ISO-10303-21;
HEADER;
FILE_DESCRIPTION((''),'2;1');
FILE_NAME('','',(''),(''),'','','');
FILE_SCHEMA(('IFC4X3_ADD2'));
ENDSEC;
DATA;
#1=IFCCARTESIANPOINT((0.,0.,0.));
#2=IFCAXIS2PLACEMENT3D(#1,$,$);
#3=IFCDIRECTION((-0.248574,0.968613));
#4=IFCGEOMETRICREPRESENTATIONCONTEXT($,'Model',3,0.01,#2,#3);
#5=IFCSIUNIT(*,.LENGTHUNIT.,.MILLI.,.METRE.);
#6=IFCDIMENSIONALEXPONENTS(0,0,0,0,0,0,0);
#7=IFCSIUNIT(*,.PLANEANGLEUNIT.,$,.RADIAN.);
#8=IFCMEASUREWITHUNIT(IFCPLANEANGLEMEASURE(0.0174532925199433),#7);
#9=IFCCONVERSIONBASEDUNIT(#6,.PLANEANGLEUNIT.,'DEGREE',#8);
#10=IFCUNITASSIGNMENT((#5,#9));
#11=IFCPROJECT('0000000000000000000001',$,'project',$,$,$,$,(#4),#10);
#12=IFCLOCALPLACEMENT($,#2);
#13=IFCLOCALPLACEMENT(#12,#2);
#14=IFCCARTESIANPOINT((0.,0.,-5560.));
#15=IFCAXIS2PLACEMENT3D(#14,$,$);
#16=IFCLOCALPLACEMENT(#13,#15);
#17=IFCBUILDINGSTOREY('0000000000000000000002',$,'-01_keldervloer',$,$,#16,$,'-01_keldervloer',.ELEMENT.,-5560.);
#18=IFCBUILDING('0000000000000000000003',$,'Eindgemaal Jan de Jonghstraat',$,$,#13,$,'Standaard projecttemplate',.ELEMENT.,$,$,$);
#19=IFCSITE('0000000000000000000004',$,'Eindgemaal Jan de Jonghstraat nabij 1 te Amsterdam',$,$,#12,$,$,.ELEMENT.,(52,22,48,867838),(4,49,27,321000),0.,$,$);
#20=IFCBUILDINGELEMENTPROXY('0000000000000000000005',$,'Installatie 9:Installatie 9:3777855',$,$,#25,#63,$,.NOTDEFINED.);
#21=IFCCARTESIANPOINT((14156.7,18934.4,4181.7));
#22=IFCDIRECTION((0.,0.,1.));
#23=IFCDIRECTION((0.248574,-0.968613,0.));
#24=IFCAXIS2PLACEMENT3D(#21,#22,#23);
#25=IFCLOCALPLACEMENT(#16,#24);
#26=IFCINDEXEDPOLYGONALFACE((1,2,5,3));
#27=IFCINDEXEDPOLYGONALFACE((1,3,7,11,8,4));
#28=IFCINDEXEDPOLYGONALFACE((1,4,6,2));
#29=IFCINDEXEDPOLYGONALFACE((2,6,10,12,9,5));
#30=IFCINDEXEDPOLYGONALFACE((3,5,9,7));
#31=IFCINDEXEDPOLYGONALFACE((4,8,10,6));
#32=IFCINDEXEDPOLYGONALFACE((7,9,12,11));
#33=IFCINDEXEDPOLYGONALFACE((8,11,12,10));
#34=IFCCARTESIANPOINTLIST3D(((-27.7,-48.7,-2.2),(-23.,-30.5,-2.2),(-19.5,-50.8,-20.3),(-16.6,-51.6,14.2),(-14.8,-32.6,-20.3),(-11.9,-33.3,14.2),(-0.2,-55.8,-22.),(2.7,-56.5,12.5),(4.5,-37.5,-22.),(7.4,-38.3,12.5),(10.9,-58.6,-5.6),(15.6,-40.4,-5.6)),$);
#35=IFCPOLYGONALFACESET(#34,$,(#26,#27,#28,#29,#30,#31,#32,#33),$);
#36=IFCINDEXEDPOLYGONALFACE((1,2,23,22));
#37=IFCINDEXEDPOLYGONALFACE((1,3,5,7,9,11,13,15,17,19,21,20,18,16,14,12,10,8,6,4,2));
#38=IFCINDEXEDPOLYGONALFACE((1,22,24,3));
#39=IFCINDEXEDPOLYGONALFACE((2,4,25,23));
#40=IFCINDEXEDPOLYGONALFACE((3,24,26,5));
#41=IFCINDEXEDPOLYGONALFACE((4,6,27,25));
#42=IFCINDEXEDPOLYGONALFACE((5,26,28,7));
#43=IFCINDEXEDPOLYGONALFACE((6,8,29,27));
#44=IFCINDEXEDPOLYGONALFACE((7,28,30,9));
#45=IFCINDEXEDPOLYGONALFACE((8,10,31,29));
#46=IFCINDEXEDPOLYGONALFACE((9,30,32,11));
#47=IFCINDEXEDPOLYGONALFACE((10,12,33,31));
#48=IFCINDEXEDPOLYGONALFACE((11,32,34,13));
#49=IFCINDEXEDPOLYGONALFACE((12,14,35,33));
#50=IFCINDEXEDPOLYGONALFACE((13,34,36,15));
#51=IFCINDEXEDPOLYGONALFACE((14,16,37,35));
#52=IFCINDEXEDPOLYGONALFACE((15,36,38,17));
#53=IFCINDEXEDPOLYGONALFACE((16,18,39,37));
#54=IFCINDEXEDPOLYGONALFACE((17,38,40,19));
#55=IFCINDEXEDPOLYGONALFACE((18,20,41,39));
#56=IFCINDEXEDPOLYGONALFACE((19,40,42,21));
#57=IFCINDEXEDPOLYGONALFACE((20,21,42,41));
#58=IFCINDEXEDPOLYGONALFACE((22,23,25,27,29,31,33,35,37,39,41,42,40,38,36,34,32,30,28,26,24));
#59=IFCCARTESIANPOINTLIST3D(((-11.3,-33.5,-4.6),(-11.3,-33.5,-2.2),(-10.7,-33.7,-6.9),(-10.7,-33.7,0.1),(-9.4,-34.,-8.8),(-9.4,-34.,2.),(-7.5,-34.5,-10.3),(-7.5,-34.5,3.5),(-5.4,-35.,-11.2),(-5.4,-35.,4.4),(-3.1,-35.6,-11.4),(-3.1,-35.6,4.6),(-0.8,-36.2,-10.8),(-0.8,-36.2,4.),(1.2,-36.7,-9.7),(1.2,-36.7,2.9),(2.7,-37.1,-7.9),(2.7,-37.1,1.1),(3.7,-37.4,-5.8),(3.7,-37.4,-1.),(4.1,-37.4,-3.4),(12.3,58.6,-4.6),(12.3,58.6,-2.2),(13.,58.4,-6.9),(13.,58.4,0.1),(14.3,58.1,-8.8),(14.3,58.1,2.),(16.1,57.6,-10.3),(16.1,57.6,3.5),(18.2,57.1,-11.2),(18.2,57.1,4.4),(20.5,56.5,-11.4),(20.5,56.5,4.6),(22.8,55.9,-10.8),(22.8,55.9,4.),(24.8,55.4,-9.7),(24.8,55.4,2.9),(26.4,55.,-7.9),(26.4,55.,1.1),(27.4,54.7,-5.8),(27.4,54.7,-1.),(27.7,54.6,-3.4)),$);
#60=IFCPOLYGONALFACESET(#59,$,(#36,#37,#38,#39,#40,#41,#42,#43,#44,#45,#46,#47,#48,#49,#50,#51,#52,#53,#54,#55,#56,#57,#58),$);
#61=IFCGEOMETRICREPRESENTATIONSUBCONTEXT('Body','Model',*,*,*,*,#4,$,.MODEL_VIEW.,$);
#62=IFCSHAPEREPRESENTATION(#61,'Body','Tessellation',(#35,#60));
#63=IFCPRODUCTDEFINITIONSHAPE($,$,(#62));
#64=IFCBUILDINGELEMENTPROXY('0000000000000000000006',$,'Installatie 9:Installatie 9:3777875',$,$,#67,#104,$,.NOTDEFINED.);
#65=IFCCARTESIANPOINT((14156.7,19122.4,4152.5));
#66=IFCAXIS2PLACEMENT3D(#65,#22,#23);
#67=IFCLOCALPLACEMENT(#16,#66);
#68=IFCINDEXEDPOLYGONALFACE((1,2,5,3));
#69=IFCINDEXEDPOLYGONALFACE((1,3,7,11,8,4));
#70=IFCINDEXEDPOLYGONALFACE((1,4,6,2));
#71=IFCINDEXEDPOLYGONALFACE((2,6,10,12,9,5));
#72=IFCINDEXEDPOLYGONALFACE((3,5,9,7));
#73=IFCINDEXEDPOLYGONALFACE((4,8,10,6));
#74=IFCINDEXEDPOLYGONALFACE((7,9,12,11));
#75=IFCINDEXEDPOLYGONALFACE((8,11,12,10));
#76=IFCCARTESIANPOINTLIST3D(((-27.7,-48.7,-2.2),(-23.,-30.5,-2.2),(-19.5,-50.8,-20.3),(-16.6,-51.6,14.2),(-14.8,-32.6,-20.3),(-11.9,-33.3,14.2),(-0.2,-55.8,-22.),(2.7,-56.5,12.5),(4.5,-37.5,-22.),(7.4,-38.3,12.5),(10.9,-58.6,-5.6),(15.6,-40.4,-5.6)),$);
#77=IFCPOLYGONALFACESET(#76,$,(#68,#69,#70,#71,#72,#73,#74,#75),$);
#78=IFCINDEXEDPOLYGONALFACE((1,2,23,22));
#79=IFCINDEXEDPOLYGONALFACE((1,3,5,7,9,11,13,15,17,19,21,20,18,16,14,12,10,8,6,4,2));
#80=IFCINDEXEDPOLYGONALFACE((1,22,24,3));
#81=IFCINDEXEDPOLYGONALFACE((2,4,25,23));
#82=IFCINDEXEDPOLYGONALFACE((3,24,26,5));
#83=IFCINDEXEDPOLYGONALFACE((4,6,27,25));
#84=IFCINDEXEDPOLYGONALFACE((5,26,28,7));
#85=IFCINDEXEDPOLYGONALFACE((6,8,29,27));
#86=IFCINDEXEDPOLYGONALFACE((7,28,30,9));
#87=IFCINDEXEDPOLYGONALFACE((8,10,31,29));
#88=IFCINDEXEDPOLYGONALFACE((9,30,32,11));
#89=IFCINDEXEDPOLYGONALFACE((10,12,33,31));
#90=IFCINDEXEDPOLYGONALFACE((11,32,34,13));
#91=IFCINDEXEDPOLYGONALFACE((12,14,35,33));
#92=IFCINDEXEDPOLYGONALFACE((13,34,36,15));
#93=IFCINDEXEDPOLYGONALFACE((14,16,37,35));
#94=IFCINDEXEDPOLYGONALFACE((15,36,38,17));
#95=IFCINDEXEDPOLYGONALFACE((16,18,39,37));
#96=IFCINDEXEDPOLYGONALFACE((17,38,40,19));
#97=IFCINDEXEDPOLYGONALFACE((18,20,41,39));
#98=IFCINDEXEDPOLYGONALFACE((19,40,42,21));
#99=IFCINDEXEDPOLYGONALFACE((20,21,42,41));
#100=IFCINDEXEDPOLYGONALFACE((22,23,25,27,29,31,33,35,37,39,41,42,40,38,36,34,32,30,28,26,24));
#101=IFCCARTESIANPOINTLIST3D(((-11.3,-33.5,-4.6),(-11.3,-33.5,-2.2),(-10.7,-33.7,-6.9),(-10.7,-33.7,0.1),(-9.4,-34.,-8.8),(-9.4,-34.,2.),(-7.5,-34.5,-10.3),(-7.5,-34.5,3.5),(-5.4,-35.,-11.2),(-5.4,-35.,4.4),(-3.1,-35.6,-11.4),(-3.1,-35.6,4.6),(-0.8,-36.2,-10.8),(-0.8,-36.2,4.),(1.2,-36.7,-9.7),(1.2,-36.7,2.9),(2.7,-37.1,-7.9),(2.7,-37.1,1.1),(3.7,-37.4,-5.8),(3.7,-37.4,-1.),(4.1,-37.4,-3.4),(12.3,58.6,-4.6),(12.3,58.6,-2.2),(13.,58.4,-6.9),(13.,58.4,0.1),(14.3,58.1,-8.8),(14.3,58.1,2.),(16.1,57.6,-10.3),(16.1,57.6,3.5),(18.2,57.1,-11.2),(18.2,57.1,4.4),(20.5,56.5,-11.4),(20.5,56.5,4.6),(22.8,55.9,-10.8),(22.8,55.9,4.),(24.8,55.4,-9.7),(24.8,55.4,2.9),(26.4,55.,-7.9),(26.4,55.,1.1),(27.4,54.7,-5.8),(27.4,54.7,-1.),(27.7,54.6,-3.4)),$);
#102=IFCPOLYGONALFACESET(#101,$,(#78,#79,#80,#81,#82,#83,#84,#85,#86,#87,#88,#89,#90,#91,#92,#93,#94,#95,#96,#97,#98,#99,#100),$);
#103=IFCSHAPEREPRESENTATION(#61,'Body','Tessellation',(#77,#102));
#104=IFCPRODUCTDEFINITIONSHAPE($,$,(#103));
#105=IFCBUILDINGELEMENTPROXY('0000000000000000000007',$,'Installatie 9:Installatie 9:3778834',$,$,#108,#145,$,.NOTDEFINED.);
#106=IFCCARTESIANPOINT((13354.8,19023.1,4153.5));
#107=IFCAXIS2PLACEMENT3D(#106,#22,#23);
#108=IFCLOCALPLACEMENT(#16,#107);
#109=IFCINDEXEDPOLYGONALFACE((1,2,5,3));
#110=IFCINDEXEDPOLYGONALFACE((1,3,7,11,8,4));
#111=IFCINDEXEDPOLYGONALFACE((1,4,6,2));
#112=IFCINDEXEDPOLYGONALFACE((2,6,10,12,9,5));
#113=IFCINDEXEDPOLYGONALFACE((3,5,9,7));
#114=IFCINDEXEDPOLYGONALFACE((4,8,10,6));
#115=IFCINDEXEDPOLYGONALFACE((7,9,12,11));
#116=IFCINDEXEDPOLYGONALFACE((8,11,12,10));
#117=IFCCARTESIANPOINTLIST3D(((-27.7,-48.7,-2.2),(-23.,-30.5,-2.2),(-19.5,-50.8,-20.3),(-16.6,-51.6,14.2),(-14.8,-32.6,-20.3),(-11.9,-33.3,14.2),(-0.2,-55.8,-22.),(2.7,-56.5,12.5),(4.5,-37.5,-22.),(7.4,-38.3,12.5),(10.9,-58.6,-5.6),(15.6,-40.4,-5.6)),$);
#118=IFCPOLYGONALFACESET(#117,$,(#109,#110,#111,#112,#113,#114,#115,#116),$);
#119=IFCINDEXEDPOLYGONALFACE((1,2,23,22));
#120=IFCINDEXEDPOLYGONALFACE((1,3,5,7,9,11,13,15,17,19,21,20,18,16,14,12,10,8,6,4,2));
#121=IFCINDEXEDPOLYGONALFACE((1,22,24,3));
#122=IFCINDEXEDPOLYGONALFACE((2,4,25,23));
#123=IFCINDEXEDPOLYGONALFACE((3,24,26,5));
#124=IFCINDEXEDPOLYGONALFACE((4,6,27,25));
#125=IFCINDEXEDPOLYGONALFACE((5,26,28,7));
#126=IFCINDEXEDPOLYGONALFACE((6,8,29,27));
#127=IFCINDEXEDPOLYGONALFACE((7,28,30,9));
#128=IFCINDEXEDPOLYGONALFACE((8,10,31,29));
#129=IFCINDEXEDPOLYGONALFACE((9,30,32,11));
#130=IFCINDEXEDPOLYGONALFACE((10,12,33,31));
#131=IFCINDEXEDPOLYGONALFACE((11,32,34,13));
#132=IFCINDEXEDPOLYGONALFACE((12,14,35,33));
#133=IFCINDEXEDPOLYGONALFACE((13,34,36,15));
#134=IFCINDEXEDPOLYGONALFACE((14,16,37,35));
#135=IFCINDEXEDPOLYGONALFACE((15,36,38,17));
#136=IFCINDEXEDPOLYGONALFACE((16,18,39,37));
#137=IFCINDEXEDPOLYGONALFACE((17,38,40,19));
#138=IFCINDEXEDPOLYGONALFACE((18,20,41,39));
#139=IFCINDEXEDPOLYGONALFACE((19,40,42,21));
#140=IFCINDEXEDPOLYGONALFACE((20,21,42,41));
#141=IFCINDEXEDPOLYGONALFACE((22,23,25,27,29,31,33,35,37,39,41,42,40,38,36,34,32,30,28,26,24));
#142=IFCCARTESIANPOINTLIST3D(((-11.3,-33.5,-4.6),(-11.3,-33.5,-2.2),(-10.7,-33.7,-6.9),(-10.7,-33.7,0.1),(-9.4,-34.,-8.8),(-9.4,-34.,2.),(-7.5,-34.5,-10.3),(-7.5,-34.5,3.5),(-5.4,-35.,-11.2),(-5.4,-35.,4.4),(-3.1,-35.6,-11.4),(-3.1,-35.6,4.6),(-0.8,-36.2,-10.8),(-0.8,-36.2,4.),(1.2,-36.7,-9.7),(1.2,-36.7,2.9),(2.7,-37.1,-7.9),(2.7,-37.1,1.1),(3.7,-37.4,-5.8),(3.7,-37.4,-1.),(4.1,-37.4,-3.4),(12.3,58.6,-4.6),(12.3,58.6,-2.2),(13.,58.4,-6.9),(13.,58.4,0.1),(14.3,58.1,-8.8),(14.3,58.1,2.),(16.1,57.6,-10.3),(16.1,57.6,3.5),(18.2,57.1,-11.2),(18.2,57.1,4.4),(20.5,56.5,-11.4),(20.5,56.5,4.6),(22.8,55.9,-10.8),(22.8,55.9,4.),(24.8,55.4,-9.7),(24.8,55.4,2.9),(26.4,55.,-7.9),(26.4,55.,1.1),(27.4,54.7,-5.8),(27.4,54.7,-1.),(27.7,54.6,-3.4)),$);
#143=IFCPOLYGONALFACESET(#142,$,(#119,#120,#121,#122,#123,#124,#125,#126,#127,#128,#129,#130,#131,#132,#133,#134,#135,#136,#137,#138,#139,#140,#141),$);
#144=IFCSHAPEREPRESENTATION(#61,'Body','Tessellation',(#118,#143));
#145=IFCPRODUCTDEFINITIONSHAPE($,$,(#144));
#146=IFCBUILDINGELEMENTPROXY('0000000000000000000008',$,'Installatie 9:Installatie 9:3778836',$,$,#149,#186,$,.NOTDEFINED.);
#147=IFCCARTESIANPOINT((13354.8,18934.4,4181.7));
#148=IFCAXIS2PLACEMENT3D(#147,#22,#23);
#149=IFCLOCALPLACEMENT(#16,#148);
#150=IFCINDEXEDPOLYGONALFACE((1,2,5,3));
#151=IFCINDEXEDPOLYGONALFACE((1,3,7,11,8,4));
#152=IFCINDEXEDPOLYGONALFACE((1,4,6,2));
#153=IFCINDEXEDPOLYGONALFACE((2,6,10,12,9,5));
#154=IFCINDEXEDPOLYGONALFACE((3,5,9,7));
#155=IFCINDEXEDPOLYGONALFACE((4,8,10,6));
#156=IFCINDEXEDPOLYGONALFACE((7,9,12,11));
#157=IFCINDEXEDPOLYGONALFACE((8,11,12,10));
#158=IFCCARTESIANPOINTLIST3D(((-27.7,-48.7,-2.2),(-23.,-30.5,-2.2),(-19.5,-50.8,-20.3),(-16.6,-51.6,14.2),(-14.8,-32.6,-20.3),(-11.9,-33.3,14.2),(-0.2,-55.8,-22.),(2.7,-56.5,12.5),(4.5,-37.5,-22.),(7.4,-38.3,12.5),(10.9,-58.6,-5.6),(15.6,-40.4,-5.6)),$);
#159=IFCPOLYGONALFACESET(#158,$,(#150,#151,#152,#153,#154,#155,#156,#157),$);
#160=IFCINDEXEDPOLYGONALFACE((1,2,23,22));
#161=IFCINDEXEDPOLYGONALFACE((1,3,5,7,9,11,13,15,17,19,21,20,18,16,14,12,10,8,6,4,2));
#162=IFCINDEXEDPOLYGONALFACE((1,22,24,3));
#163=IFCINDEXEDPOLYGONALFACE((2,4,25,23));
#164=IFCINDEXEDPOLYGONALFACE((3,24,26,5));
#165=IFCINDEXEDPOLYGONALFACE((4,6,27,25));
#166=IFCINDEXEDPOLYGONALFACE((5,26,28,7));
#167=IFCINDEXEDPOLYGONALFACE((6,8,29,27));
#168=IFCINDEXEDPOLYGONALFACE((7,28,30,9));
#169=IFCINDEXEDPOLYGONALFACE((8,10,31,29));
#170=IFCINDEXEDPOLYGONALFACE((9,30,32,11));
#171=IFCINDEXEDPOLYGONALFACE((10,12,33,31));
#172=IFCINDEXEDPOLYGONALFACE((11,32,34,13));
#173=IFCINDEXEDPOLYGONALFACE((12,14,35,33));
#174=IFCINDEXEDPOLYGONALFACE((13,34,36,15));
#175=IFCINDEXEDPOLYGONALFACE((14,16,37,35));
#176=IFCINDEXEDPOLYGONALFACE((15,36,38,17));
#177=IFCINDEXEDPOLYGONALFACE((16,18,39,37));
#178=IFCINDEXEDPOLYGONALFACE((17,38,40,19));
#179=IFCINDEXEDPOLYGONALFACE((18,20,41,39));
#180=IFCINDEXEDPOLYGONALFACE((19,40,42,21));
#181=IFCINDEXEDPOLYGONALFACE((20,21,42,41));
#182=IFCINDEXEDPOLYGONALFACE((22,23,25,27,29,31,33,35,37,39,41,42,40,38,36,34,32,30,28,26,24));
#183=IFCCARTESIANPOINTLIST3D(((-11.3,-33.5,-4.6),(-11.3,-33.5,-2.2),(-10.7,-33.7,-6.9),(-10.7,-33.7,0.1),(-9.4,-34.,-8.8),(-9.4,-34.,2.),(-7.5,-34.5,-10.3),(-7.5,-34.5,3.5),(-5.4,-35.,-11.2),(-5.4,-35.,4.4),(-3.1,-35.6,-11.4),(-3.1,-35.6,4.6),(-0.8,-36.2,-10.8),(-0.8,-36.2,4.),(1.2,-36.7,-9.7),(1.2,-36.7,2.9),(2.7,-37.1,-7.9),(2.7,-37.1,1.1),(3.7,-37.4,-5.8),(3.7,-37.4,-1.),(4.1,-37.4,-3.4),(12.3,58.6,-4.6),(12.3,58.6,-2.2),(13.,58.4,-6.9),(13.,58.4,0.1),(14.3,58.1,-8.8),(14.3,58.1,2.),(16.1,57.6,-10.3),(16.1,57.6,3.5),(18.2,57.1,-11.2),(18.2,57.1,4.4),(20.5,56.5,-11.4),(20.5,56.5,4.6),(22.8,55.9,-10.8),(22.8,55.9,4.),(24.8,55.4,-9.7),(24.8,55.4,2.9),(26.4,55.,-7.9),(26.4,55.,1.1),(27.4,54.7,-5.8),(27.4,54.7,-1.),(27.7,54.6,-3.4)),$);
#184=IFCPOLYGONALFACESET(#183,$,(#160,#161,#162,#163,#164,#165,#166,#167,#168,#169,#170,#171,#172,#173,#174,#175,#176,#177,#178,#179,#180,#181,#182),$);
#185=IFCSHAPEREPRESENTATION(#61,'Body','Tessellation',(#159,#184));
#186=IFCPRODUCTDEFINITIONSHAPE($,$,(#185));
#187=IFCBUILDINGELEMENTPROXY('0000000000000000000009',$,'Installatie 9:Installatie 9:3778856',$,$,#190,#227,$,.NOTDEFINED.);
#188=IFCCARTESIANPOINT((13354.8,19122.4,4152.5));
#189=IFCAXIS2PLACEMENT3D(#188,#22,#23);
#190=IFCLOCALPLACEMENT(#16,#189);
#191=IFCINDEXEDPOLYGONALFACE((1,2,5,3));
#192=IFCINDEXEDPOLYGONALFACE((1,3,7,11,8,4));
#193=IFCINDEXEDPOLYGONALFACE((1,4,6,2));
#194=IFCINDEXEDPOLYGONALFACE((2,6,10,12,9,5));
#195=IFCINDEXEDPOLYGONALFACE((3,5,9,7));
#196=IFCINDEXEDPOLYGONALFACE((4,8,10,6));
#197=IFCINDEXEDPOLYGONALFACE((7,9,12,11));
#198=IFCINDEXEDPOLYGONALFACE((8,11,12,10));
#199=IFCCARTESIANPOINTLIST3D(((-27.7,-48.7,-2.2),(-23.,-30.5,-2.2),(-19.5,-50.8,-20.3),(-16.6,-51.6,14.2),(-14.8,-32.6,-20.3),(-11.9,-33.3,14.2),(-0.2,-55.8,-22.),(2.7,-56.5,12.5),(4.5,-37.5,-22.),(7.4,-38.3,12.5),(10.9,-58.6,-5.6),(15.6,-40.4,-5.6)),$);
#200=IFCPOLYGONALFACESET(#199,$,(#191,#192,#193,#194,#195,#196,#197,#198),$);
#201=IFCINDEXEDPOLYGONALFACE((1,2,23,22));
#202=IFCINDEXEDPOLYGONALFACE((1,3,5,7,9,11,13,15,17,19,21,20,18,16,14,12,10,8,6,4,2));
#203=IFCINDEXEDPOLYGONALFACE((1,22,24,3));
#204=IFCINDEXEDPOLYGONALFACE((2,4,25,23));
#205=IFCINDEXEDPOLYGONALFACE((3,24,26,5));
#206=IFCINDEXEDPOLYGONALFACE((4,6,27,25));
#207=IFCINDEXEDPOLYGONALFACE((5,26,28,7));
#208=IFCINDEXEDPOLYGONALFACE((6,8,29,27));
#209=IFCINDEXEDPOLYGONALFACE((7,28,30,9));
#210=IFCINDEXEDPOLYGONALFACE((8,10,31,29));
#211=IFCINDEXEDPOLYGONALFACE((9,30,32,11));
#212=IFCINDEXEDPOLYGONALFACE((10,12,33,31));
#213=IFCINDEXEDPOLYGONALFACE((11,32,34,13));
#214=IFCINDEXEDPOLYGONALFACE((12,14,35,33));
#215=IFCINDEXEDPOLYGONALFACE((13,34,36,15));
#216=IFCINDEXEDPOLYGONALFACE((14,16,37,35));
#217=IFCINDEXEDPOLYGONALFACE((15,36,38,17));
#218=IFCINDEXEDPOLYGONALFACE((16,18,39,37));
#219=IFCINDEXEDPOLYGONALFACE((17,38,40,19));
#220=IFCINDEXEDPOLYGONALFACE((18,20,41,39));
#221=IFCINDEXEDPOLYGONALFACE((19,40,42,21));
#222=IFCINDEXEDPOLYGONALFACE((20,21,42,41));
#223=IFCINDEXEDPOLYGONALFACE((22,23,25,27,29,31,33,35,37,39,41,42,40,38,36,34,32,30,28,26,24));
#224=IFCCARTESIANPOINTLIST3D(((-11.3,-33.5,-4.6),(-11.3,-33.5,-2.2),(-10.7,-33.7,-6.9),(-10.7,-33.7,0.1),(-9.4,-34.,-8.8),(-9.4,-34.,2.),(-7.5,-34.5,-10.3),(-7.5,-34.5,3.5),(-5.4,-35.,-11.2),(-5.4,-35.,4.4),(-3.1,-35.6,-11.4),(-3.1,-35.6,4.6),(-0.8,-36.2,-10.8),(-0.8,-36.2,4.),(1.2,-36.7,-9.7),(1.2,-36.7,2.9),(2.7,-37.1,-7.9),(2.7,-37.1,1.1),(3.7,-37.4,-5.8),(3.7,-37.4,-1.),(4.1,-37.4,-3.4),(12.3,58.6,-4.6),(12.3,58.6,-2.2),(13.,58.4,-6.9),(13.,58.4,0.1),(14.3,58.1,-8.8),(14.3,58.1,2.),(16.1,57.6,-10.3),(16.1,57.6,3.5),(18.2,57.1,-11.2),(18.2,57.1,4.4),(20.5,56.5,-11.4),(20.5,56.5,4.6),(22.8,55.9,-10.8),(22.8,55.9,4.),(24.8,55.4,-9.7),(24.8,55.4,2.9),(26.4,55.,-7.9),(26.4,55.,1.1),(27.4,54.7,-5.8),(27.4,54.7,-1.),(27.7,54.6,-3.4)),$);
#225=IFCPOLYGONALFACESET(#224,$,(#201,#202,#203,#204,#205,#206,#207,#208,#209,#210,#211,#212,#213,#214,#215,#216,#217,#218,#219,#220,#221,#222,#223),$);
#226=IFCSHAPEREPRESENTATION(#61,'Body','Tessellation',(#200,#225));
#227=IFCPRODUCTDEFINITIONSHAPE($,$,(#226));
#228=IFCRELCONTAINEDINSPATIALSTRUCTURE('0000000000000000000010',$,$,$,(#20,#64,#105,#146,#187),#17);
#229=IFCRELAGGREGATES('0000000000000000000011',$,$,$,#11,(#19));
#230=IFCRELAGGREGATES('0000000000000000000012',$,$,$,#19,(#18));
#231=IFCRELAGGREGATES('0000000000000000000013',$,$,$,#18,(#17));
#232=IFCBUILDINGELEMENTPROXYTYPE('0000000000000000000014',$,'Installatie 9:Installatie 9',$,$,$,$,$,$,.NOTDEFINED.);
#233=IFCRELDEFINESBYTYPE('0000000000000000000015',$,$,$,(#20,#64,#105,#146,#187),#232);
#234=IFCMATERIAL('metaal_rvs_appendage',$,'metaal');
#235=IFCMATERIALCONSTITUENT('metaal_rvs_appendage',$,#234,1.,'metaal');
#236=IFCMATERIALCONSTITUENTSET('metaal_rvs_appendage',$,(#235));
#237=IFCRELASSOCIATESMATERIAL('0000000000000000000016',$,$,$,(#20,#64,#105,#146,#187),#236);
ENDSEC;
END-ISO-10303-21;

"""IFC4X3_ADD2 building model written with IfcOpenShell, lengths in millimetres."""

from ifc_helpers import new_model, entity, si_unit, converted_unit, direction, frame, frame_2d, origin, place, context, subcontext, project, spatial, polyline, circle, outline, extrude, source, transform, mapped, material, constituent, constituent_set, type_object, type_shapes, element, save


model = new_model("IFC4X3_ADD2")

# Units and contexts
model_context = context("Model", 3, precision=0.01, world=origin(), true_north=direction((-0.248574, 0.968613)))
body_context = subcontext(model_context, "Body", "Model", "MODEL_VIEW")
ifc_project = project(units=[si_unit("LENGTHUNIT", "METRE", prefix="MILLI"), converted_unit("PLANEANGLEUNIT", "DEGREE", entity("IfcPlaneAngleMeasure", 0.0174532925199433), si_unit("PLANEANGLEUNIT", "RADIAN"), dimensions=[0, 0, 0, 0, 0, 0, 0])], contexts=[model_context])

# Site, building, storey
site_placement = place(None, origin())
site = spatial("IfcSite", under=ifc_project, at=site_placement, Name="Eindgemaal Jan de Jonghstraat nabij 1 te Amsterdam", CompositionType="ELEMENT", RefLatitude=(52, 22, 48, 867838), RefLongitude=(4, 49, 27, 321000), RefElevation=0.0)
building_placement = place(site_placement, origin())
building = spatial("IfcBuilding", under=site, at=building_placement, Name="Eindgemaal Jan de Jonghstraat", LongName="Standaard projecttemplate", CompositionType="ELEMENT")
storey_placement = place(building_placement, frame((0.0, 0.0, -5560.0)))
storey = spatial("IfcBuildingStorey", under=building, at=storey_placement, Name="-01_keldervloer", LongName="-01_keldervloer", CompositionType="ELEMENT", Elevation=-5560.0)

# Building element proxies
ifc_material_1 = material(Name="metaal_rvs_appendage", Category="metaal")
ifc_constituent_1 = constituent(ifc_material_1, Name="metaal_rvs_appendage", Category="metaal", fraction=1.0)
ifc_constituent_set_1 = constituent_set(constituents=[ifc_constituent_1], Name="metaal_rvs_appendage")
building_element_proxy_type = type_object("IfcBuildingElementProxyType", Name="Installatie 9:Installatie 9", PredefinedType="NOTDEFINED")
shared_shape_1 = source(origin(), body_context, "Body", "SweptSolid", [
    extrude(outline(polyline([(-10.0, -17.3), (10.0, -17.3), (20.0, 0.0), (10.0, 17.3), (-10.0, 17.3), (-20.0, 0.0), (-10.0, -17.3)])), frame((-8.4, -53.7, -3.9), z_axis=(0.248574, 0.968613, 0.0), x_axis=(-0.555573, 0.142576, -0.819152)), (0.0, 0.0, 1.0), 18.8),
    extrude(circle(Radius=8.0, at=frame_2d((0.0, 0.0), x_axis=(1.0, 0.0))), frame((-3.7, -35.5, -3.4), z_axis=(0.248574, 0.968613, 0.0), x_axis=(0.968613, -0.248574, 0.0)), (0.0, 0.0, 1.0), 95.1),
])
type_shapes(building_element_proxy_type, [shared_shape_1])
for number, where, z_axis, x_axis, name in (
    (1, (14156.7, 18934.4, 4181.7), (0.0, 0.0, 1.0), (0.248574, -0.968613, 0.0), "Installatie 9:Installatie 9:3777855"),
    (2, (14156.7, 19122.4, 4152.5), (0.0, 0.0, 1.0), (0.248574, -0.968613, 0.0), "Installatie 9:Installatie 9:3777875"),
    (3, (13354.8, 19023.1, 4153.5), (0.0, 0.0, 1.0), (0.248574, -0.968613, 0.0), "Installatie 9:Installatie 9:3778834"),
    (4, (13354.8, 18934.4, 4181.7), (0.0, 0.0, 1.0), (0.248574, -0.968613, 0.0), "Installatie 9:Installatie 9:3778836"),
    (5, (13354.8, 19122.4, 4152.5), (0.0, 0.0, 1.0), (0.248574, -0.968613, 0.0), "Installatie 9:Installatie 9:3778856"),
):
    element("IfcBuildingElementProxy", number, at=place(storey_placement, frame(where, z_axis=z_axis, x_axis=x_axis)), inside=storey, type_object=building_element_proxy_type, material=ifc_constituent_set_1, Name=name, PredefinedType="NOTDEFINED", context=body_context, shape_type="MappedRepresentation", body=[
        mapped(shared_shape_1, transform((0.0, 0.0, 0.0), scale=1.0)),
    ])

save(model, "model.ifc")
